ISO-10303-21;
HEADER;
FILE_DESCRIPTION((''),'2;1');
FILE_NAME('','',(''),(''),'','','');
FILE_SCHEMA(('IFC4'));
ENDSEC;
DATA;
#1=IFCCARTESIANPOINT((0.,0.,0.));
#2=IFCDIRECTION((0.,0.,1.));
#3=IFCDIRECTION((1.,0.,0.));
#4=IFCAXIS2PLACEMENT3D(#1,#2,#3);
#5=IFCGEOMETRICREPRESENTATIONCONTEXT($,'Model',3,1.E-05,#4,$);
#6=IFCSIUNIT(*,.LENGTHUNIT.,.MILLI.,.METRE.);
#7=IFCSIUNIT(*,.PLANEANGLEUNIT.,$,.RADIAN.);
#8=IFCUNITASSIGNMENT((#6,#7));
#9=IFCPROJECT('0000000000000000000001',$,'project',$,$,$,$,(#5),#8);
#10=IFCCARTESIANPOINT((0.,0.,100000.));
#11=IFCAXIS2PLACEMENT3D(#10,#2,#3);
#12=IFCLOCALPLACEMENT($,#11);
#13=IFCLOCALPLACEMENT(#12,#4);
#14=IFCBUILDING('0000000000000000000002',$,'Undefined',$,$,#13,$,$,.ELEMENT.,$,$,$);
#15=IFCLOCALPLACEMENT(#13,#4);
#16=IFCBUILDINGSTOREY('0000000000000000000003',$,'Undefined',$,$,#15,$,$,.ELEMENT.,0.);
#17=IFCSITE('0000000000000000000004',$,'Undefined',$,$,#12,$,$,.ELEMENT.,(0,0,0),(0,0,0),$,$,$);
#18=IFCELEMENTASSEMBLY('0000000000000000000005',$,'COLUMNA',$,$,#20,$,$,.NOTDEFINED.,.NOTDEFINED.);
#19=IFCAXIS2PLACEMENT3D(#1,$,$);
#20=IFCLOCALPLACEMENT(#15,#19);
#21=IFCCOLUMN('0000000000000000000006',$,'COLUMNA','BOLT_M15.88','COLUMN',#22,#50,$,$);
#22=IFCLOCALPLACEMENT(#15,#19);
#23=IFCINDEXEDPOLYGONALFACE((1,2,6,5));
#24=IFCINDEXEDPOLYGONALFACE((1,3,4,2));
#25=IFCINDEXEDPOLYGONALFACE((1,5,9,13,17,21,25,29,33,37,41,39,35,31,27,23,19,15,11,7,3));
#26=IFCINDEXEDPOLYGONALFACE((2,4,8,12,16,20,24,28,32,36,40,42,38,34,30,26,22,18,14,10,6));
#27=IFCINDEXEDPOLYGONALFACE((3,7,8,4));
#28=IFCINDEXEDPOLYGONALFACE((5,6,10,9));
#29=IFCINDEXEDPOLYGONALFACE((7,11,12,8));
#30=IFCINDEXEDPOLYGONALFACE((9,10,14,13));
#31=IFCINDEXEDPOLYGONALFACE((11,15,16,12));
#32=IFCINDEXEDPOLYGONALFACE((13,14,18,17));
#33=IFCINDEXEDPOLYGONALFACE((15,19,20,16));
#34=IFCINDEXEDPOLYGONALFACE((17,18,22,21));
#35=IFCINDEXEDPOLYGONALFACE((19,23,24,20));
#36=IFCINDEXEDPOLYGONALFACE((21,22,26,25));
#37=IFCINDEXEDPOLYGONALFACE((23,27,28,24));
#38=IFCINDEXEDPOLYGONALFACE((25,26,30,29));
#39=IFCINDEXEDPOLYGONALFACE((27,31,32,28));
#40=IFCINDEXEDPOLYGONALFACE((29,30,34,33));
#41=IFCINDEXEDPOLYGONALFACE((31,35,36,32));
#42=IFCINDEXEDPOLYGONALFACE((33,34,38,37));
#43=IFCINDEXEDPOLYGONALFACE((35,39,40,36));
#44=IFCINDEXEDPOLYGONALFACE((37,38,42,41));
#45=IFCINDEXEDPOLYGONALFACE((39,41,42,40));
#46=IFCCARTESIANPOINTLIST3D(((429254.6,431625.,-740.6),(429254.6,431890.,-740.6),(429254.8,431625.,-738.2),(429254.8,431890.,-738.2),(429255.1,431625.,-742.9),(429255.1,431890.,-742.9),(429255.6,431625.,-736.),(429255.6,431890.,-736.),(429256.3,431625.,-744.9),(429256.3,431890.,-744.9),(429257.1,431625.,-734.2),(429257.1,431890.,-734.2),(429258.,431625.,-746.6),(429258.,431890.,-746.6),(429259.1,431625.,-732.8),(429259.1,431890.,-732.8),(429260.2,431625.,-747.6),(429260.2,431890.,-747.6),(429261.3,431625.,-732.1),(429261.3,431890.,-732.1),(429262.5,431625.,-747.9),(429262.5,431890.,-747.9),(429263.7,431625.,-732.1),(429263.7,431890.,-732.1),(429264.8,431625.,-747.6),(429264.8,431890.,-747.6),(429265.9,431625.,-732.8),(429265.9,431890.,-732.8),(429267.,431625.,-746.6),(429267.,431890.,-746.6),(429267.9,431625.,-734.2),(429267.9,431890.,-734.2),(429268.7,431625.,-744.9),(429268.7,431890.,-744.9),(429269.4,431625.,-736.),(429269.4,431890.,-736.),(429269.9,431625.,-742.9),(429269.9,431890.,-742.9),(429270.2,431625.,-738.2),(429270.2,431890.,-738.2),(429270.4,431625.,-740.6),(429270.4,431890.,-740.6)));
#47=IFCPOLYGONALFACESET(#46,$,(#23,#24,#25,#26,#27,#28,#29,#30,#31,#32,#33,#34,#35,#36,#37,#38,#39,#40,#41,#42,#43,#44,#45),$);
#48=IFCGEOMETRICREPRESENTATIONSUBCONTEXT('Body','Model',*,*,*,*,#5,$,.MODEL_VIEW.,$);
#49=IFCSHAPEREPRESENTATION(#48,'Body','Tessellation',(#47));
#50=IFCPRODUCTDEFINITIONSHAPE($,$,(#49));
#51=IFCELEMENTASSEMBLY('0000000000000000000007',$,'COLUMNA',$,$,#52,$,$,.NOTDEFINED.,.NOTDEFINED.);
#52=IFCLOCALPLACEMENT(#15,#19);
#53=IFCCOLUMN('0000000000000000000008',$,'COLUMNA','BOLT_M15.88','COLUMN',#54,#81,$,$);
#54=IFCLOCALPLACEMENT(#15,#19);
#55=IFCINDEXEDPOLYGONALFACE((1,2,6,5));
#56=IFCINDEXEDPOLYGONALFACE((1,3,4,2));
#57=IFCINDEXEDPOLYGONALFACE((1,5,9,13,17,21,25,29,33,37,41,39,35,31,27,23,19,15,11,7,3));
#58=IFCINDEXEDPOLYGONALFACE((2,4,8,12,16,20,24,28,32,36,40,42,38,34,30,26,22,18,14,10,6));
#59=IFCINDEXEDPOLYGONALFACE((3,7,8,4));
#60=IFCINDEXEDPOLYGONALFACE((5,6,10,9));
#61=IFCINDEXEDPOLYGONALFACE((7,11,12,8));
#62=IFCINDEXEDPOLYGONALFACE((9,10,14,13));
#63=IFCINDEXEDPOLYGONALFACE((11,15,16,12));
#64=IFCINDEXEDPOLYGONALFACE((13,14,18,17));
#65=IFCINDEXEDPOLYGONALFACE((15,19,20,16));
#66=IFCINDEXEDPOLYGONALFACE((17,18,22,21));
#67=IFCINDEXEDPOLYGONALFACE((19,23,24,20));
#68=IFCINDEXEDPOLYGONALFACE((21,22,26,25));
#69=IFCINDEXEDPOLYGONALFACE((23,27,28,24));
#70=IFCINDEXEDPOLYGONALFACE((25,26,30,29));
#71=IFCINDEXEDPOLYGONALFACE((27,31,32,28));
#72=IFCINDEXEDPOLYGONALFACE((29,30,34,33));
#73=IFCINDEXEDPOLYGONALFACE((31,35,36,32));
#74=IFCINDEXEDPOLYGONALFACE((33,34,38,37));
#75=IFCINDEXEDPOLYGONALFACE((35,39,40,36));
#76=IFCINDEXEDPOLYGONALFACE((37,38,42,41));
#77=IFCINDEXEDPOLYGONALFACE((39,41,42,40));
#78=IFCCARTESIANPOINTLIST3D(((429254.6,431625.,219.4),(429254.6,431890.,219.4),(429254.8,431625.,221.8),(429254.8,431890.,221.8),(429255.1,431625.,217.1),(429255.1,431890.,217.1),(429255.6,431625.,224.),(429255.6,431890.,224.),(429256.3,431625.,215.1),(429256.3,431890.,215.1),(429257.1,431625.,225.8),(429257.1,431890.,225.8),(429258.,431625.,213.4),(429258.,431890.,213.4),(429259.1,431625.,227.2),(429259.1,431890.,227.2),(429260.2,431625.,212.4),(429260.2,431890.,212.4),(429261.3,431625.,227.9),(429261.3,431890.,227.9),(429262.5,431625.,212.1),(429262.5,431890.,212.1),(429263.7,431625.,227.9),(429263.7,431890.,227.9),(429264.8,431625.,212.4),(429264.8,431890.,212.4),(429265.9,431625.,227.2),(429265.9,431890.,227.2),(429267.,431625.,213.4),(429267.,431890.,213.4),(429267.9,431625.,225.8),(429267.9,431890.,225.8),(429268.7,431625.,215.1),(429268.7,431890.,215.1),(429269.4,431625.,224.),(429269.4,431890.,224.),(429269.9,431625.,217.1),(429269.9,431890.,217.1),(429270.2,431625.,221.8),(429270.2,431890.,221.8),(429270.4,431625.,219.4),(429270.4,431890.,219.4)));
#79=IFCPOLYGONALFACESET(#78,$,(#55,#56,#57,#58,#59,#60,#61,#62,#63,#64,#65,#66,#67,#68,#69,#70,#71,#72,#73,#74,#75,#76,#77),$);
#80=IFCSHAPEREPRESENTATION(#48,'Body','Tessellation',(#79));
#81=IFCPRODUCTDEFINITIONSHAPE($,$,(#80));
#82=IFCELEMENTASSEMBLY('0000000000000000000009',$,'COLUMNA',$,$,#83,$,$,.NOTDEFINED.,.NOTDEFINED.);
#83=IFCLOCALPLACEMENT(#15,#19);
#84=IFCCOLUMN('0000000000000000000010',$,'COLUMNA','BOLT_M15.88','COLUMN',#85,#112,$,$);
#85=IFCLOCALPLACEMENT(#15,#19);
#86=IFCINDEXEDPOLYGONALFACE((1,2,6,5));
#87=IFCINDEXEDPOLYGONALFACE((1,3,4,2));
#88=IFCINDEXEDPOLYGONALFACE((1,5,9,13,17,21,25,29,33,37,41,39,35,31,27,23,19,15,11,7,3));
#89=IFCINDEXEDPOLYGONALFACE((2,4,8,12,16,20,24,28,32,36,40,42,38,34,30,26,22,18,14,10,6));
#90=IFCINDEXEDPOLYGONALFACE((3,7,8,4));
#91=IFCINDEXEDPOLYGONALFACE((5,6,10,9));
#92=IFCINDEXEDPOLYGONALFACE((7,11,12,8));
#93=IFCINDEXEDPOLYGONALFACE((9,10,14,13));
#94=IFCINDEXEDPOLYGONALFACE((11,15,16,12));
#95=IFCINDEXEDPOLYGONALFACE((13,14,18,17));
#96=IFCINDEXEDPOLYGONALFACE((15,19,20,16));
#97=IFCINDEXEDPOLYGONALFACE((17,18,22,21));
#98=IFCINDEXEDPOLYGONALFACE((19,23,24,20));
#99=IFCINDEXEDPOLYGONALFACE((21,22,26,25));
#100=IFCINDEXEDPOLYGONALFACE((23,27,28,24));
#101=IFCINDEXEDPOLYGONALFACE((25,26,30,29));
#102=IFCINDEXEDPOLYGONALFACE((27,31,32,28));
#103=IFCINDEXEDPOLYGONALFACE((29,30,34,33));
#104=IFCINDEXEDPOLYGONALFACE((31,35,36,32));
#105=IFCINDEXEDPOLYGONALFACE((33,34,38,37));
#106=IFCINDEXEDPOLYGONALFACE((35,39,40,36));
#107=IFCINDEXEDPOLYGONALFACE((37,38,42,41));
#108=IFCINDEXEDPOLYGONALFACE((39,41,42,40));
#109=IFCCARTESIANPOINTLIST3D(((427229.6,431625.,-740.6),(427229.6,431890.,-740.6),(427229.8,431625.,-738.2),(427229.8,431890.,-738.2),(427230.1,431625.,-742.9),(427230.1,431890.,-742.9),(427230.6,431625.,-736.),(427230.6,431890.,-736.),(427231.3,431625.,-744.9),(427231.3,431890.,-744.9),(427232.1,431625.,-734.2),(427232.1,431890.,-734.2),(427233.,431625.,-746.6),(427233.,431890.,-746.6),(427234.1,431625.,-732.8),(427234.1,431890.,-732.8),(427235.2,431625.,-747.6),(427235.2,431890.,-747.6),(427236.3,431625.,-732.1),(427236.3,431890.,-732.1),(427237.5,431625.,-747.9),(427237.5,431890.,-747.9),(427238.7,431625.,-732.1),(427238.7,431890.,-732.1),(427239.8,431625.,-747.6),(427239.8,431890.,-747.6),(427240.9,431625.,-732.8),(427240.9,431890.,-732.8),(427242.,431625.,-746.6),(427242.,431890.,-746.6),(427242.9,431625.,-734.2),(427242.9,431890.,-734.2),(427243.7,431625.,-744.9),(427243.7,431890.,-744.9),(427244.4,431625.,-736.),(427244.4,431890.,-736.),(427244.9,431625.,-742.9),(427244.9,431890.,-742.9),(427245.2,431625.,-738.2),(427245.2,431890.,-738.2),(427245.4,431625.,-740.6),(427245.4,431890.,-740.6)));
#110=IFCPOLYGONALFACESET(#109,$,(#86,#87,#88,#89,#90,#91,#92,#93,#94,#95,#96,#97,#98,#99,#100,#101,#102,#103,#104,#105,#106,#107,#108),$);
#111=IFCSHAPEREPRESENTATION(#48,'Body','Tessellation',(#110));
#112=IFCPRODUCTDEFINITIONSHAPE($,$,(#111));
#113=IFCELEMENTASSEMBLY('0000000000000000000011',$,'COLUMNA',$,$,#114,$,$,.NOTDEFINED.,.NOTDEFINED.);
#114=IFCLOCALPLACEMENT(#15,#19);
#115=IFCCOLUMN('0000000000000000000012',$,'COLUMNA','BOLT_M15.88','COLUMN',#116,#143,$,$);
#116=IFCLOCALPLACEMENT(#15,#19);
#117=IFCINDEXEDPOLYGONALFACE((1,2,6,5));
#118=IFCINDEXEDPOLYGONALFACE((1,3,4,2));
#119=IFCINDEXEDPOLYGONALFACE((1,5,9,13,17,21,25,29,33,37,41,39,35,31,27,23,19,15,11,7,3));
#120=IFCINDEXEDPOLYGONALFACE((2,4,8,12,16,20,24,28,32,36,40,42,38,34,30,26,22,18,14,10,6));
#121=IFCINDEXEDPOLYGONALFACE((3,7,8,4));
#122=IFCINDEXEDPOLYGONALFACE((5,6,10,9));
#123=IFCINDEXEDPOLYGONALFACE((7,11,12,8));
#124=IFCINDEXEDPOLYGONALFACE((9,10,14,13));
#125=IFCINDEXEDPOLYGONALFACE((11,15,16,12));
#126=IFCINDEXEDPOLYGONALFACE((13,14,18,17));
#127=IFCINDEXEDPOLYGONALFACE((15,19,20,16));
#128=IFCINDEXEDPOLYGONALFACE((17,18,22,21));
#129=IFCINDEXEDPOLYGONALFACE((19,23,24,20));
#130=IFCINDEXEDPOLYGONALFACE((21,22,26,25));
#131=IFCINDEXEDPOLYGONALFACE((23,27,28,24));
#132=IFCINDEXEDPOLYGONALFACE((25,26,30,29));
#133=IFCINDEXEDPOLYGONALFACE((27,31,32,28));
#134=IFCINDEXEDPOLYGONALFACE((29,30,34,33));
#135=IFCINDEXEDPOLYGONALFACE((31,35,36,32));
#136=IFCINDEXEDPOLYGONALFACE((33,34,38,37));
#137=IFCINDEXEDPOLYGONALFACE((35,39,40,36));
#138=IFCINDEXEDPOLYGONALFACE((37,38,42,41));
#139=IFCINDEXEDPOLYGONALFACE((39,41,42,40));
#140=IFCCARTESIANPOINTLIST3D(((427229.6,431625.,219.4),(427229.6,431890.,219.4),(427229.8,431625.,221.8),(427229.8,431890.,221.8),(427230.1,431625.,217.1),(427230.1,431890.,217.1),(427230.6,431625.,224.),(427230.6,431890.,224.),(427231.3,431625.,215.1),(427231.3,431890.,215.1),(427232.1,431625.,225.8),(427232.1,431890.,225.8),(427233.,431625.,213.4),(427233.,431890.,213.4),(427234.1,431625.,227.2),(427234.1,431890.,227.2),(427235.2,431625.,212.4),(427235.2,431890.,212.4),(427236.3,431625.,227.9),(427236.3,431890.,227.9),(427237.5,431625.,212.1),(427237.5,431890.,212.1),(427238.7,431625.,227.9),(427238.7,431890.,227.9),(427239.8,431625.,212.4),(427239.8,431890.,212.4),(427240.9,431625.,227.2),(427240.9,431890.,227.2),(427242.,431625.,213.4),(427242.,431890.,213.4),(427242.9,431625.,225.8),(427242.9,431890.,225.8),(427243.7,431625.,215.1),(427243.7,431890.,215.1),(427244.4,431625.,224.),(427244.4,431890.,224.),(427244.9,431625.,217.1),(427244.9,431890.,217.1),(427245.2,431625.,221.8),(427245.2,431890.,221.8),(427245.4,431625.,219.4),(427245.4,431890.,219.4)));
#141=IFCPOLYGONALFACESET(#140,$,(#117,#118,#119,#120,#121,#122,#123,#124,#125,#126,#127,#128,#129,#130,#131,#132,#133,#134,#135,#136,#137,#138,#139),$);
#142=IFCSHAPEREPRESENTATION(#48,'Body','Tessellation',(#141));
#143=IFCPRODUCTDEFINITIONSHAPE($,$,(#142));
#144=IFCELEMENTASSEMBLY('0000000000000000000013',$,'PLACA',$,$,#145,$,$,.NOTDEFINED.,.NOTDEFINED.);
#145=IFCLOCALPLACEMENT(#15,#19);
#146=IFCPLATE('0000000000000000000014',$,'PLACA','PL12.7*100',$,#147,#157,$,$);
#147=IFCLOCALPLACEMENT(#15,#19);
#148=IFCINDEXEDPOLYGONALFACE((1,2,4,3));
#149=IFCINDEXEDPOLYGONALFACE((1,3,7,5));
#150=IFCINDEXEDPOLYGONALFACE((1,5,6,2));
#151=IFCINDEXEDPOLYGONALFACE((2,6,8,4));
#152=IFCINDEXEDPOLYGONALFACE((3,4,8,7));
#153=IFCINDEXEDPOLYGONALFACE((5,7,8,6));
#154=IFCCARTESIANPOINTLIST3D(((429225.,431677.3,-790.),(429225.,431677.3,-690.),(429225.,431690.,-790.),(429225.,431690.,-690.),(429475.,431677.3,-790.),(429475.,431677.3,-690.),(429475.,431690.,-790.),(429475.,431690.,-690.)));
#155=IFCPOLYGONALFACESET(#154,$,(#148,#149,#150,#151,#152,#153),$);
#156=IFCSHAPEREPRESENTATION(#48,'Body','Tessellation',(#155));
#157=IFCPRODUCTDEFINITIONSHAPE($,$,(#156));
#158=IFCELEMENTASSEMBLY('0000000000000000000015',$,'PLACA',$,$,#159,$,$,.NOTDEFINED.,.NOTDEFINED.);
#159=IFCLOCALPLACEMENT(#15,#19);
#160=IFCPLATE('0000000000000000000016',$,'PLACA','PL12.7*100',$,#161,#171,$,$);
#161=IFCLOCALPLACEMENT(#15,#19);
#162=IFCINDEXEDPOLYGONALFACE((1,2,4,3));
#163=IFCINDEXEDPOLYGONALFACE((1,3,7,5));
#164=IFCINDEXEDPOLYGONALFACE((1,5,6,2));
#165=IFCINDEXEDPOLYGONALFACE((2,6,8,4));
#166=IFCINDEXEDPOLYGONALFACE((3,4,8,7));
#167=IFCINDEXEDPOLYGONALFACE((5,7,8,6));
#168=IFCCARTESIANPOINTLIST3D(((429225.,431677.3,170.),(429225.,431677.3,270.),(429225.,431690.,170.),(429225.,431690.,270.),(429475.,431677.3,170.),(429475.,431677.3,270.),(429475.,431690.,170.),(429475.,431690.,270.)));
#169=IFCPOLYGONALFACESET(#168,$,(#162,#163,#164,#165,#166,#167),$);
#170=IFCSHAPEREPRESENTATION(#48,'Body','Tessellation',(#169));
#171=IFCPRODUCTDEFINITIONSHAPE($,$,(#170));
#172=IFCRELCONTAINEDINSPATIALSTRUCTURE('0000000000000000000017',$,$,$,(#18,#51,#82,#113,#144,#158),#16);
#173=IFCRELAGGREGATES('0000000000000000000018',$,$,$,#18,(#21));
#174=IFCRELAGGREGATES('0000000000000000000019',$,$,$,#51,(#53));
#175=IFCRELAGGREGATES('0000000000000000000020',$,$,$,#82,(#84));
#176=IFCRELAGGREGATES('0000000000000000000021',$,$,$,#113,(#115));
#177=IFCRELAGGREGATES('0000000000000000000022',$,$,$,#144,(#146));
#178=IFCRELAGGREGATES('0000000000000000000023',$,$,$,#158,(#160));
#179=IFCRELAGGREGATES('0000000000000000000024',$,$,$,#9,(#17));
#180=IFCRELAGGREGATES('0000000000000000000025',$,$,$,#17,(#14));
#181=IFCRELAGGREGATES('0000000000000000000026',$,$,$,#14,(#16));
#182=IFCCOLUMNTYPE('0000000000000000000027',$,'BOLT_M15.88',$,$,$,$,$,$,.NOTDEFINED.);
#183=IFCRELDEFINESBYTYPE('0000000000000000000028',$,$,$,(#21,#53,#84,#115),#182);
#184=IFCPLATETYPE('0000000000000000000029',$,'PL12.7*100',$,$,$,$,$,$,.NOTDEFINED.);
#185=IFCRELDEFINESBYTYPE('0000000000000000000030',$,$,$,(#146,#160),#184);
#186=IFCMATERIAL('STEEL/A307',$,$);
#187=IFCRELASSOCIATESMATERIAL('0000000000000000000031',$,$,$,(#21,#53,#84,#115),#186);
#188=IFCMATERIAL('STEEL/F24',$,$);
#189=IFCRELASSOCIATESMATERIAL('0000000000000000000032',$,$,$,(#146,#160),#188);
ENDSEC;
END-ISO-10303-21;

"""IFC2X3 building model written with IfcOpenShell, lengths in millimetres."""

from ifc_helpers import new_model, si_unit, frame, origin_with_axes, origin_2d_with_axis, place, context, subcontext, project, spatial, polyline, circle, outline, extrude, material, type_object, element, aggregate, save


model = new_model("IFC2X3")

# Units and contexts
model_context = context("Model", 3, precision=1e-05, world=origin_with_axes())
body_context = subcontext(model_context, "Body", "Model", "MODEL_VIEW")
ifc_project = project(units=[si_unit("LENGTHUNIT", "METRE", prefix="MILLI"), si_unit("PLANEANGLEUNIT", "RADIAN")], contexts=[model_context])

# Site, building, storey
site_placement = place(None, frame((0.0, 0.0, 100000.0), z_axis=(0.0, 0.0, 1.0), x_axis=(1.0, 0.0, 0.0)))
site = spatial("IfcSite", under=ifc_project, at=site_placement, Name="Undefined", CompositionType="ELEMENT", RefLatitude=(0, 0, 0), RefLongitude=(0, 0, 0))
building_placement = place(site_placement, origin_with_axes())
building = spatial("IfcBuilding", under=site, at=building_placement, Name="Undefined", CompositionType="ELEMENT")
storey_placement = place(building_placement, origin_with_axes())
storey = spatial("IfcBuildingStorey", under=building, at=storey_placement, Name="Undefined", CompositionType="ELEMENT", Elevation=0.0)

# Element assemblies, columns
ifc_material_1 = material(Name="STEEL/A307")
column_type_1 = type_object("IfcColumnType", Name="BOLT_M15.88", PredefinedType="NOTDEFINED")
assembly_1_placement = place(storey_placement, origin_with_axes())
assembly_1 = element("IfcElementAssembly", 1, at=assembly_1_placement, inside=storey, Name="COLUMNA", AssemblyPlace="NOTDEFINED", PredefinedType="NOTDEFINED")
column_1_placement = place(assembly_1_placement, frame((429262.5, 431890.0, -740.0), z_axis=(0.0, -1.0, -0.000003), x_axis=(-1.0, 0.0, 0.0)))
column_1 = element("IfcColumn", 2, at=column_1_placement, type_object=column_type_1, material=ifc_material_1, Name="COLUMNA", Description="BOLT_M15.88", ObjectType="COLUMN", context=body_context, shape_type="SweptSolid", body=[
    extrude(circle(Radius=7.9, at=origin_2d_with_axis()), frame((0.0, 0.0, 265.0), z_axis=(0.0, 0.0, -1.0), x_axis=(0.0, 1.0, 0.0)), (0.0, 0.0, 1.0), 265.0),
])
aggregate(assembly_1, [column_1])
assembly_2_placement = place(storey_placement, origin_with_axes())
assembly_2 = element("IfcElementAssembly", 3, at=assembly_2_placement, inside=storey, Name="COLUMNA", AssemblyPlace="NOTDEFINED", PredefinedType="NOTDEFINED")
column_2_placement = place(assembly_2_placement, frame((429262.5, 431890.0, 220.0), z_axis=(0.0, -1.0, -0.000003), x_axis=(-1.0, 0.0, 0.0)))
column_2 = element("IfcColumn", 4, at=column_2_placement, type_object=column_type_1, material=ifc_material_1, Name="COLUMNA", Description="BOLT_M15.88", ObjectType="COLUMN", context=body_context, shape_type="SweptSolid", body=[
    extrude(circle(Radius=7.9, at=origin_2d_with_axis()), frame((0.0, 0.0, 265.0), z_axis=(0.0, 0.0, -1.0), x_axis=(0.0, 1.0, 0.0)), (0.0, 0.0, 1.0), 265.0),
])
aggregate(assembly_2, [column_2])
assembly_3_placement = place(storey_placement, origin_with_axes())
assembly_3 = element("IfcElementAssembly", 5, at=assembly_3_placement, inside=storey, Name="COLUMNA", AssemblyPlace="NOTDEFINED", PredefinedType="NOTDEFINED")
column_3_placement = place(assembly_3_placement, frame((427237.5, 431890.0, -740.0), z_axis=(0.0, -1.0, -0.000003), x_axis=(-1.0, 0.0, 0.0)))
column_3 = element("IfcColumn", 6, at=column_3_placement, type_object=column_type_1, material=ifc_material_1, Name="COLUMNA", Description="BOLT_M15.88", ObjectType="COLUMN", context=body_context, shape_type="SweptSolid", body=[
    extrude(circle(Radius=7.9, at=origin_2d_with_axis()), frame((0.0, 0.0, 265.0), z_axis=(0.0, 0.0, -1.0), x_axis=(0.0, 1.0, 0.0)), (0.0, 0.0, 1.0), 265.0),
])
aggregate(assembly_3, [column_3])
assembly_4_placement = place(storey_placement, origin_with_axes())
assembly_4 = element("IfcElementAssembly", 7, at=assembly_4_placement, inside=storey, Name="COLUMNA", AssemblyPlace="NOTDEFINED", PredefinedType="NOTDEFINED")
column_4_placement = place(assembly_4_placement, frame((427237.5, 431890.0, 220.0), z_axis=(0.0, -1.0, -0.000003), x_axis=(-1.0, 0.0, 0.0)))
column_4 = element("IfcColumn", 8, at=column_4_placement, type_object=column_type_1, material=ifc_material_1, Name="COLUMNA", Description="BOLT_M15.88", ObjectType="COLUMN", context=body_context, shape_type="SweptSolid", body=[
    extrude(circle(Radius=7.9, at=origin_2d_with_axis()), frame((0.0, 0.0, 265.0), z_axis=(0.0, 0.0, -1.0), x_axis=(0.0, 1.0, 0.0)), (0.0, 0.0, 1.0), 265.0),
])
aggregate(assembly_4, [column_4])

# Element assemblies, plates
assembly_5_placement = place(storey_placement, origin_with_axes())
assembly_5 = element("IfcElementAssembly", 9, at=assembly_5_placement, inside=storey, Name="PLACA", AssemblyPlace="NOTDEFINED", PredefinedType="NOTDEFINED")
ifc_material_2 = material(Name="STEEL/F24")
plate_type = type_object("IfcPlateType", Name="PL12.7*100", PredefinedType="NOTDEFINED")
plate_1_placement = place(assembly_5_placement, frame((429225.0, 431683.6, -690.0), z_axis=(0.0, 1.0, 0.0), x_axis=(1.0, 0.0, 0.0)))
plate_1 = element("IfcPlate", 10, at=plate_1_placement, type_object=plate_type, material=ifc_material_2, Name="PLACA", Description="PL12.7*100", context=body_context, shape_type="SweptSolid", body=[
    extrude(outline(polyline([(0.0, 0.0), (250.0, 0.0), (250.0, 100.0), (0.0, 100.0), (0.0, 0.0)])), frame((0.0, 0.0, -6.3), z_axis=(0.0, 0.0, 1.0), x_axis=(1.0, 0.0, 0.0)), (0.0, 0.0, 1.0), 12.7),
])
aggregate(assembly_5, [plate_1])
assembly_6_placement = place(storey_placement, origin_with_axes())
assembly_6 = element("IfcElementAssembly", 11, at=assembly_6_placement, inside=storey, Name="PLACA", AssemblyPlace="NOTDEFINED", PredefinedType="NOTDEFINED")
plate_2_placement = place(assembly_6_placement, frame((429225.0, 431683.6, 270.0), z_axis=(0.0, 1.0, 0.0), x_axis=(1.0, 0.0, 0.0)))
plate_2 = element("IfcPlate", 12, at=plate_2_placement, type_object=plate_type, material=ifc_material_2, Name="PLACA", Description="PL12.7*100", context=body_context, shape_type="SweptSolid", body=[
    extrude(outline(polyline([(0.0, 0.0), (250.0, 0.0), (250.0, 100.0), (0.0, 100.0), (0.0, 0.0)])), frame((0.0, 0.0, -6.3), z_axis=(0.0, 0.0, 1.0), x_axis=(1.0, 0.0, 0.0)), (0.0, 0.0, 1.0), 12.7),
])
aggregate(assembly_6, [plate_2])

save(model, "model.ifc")
